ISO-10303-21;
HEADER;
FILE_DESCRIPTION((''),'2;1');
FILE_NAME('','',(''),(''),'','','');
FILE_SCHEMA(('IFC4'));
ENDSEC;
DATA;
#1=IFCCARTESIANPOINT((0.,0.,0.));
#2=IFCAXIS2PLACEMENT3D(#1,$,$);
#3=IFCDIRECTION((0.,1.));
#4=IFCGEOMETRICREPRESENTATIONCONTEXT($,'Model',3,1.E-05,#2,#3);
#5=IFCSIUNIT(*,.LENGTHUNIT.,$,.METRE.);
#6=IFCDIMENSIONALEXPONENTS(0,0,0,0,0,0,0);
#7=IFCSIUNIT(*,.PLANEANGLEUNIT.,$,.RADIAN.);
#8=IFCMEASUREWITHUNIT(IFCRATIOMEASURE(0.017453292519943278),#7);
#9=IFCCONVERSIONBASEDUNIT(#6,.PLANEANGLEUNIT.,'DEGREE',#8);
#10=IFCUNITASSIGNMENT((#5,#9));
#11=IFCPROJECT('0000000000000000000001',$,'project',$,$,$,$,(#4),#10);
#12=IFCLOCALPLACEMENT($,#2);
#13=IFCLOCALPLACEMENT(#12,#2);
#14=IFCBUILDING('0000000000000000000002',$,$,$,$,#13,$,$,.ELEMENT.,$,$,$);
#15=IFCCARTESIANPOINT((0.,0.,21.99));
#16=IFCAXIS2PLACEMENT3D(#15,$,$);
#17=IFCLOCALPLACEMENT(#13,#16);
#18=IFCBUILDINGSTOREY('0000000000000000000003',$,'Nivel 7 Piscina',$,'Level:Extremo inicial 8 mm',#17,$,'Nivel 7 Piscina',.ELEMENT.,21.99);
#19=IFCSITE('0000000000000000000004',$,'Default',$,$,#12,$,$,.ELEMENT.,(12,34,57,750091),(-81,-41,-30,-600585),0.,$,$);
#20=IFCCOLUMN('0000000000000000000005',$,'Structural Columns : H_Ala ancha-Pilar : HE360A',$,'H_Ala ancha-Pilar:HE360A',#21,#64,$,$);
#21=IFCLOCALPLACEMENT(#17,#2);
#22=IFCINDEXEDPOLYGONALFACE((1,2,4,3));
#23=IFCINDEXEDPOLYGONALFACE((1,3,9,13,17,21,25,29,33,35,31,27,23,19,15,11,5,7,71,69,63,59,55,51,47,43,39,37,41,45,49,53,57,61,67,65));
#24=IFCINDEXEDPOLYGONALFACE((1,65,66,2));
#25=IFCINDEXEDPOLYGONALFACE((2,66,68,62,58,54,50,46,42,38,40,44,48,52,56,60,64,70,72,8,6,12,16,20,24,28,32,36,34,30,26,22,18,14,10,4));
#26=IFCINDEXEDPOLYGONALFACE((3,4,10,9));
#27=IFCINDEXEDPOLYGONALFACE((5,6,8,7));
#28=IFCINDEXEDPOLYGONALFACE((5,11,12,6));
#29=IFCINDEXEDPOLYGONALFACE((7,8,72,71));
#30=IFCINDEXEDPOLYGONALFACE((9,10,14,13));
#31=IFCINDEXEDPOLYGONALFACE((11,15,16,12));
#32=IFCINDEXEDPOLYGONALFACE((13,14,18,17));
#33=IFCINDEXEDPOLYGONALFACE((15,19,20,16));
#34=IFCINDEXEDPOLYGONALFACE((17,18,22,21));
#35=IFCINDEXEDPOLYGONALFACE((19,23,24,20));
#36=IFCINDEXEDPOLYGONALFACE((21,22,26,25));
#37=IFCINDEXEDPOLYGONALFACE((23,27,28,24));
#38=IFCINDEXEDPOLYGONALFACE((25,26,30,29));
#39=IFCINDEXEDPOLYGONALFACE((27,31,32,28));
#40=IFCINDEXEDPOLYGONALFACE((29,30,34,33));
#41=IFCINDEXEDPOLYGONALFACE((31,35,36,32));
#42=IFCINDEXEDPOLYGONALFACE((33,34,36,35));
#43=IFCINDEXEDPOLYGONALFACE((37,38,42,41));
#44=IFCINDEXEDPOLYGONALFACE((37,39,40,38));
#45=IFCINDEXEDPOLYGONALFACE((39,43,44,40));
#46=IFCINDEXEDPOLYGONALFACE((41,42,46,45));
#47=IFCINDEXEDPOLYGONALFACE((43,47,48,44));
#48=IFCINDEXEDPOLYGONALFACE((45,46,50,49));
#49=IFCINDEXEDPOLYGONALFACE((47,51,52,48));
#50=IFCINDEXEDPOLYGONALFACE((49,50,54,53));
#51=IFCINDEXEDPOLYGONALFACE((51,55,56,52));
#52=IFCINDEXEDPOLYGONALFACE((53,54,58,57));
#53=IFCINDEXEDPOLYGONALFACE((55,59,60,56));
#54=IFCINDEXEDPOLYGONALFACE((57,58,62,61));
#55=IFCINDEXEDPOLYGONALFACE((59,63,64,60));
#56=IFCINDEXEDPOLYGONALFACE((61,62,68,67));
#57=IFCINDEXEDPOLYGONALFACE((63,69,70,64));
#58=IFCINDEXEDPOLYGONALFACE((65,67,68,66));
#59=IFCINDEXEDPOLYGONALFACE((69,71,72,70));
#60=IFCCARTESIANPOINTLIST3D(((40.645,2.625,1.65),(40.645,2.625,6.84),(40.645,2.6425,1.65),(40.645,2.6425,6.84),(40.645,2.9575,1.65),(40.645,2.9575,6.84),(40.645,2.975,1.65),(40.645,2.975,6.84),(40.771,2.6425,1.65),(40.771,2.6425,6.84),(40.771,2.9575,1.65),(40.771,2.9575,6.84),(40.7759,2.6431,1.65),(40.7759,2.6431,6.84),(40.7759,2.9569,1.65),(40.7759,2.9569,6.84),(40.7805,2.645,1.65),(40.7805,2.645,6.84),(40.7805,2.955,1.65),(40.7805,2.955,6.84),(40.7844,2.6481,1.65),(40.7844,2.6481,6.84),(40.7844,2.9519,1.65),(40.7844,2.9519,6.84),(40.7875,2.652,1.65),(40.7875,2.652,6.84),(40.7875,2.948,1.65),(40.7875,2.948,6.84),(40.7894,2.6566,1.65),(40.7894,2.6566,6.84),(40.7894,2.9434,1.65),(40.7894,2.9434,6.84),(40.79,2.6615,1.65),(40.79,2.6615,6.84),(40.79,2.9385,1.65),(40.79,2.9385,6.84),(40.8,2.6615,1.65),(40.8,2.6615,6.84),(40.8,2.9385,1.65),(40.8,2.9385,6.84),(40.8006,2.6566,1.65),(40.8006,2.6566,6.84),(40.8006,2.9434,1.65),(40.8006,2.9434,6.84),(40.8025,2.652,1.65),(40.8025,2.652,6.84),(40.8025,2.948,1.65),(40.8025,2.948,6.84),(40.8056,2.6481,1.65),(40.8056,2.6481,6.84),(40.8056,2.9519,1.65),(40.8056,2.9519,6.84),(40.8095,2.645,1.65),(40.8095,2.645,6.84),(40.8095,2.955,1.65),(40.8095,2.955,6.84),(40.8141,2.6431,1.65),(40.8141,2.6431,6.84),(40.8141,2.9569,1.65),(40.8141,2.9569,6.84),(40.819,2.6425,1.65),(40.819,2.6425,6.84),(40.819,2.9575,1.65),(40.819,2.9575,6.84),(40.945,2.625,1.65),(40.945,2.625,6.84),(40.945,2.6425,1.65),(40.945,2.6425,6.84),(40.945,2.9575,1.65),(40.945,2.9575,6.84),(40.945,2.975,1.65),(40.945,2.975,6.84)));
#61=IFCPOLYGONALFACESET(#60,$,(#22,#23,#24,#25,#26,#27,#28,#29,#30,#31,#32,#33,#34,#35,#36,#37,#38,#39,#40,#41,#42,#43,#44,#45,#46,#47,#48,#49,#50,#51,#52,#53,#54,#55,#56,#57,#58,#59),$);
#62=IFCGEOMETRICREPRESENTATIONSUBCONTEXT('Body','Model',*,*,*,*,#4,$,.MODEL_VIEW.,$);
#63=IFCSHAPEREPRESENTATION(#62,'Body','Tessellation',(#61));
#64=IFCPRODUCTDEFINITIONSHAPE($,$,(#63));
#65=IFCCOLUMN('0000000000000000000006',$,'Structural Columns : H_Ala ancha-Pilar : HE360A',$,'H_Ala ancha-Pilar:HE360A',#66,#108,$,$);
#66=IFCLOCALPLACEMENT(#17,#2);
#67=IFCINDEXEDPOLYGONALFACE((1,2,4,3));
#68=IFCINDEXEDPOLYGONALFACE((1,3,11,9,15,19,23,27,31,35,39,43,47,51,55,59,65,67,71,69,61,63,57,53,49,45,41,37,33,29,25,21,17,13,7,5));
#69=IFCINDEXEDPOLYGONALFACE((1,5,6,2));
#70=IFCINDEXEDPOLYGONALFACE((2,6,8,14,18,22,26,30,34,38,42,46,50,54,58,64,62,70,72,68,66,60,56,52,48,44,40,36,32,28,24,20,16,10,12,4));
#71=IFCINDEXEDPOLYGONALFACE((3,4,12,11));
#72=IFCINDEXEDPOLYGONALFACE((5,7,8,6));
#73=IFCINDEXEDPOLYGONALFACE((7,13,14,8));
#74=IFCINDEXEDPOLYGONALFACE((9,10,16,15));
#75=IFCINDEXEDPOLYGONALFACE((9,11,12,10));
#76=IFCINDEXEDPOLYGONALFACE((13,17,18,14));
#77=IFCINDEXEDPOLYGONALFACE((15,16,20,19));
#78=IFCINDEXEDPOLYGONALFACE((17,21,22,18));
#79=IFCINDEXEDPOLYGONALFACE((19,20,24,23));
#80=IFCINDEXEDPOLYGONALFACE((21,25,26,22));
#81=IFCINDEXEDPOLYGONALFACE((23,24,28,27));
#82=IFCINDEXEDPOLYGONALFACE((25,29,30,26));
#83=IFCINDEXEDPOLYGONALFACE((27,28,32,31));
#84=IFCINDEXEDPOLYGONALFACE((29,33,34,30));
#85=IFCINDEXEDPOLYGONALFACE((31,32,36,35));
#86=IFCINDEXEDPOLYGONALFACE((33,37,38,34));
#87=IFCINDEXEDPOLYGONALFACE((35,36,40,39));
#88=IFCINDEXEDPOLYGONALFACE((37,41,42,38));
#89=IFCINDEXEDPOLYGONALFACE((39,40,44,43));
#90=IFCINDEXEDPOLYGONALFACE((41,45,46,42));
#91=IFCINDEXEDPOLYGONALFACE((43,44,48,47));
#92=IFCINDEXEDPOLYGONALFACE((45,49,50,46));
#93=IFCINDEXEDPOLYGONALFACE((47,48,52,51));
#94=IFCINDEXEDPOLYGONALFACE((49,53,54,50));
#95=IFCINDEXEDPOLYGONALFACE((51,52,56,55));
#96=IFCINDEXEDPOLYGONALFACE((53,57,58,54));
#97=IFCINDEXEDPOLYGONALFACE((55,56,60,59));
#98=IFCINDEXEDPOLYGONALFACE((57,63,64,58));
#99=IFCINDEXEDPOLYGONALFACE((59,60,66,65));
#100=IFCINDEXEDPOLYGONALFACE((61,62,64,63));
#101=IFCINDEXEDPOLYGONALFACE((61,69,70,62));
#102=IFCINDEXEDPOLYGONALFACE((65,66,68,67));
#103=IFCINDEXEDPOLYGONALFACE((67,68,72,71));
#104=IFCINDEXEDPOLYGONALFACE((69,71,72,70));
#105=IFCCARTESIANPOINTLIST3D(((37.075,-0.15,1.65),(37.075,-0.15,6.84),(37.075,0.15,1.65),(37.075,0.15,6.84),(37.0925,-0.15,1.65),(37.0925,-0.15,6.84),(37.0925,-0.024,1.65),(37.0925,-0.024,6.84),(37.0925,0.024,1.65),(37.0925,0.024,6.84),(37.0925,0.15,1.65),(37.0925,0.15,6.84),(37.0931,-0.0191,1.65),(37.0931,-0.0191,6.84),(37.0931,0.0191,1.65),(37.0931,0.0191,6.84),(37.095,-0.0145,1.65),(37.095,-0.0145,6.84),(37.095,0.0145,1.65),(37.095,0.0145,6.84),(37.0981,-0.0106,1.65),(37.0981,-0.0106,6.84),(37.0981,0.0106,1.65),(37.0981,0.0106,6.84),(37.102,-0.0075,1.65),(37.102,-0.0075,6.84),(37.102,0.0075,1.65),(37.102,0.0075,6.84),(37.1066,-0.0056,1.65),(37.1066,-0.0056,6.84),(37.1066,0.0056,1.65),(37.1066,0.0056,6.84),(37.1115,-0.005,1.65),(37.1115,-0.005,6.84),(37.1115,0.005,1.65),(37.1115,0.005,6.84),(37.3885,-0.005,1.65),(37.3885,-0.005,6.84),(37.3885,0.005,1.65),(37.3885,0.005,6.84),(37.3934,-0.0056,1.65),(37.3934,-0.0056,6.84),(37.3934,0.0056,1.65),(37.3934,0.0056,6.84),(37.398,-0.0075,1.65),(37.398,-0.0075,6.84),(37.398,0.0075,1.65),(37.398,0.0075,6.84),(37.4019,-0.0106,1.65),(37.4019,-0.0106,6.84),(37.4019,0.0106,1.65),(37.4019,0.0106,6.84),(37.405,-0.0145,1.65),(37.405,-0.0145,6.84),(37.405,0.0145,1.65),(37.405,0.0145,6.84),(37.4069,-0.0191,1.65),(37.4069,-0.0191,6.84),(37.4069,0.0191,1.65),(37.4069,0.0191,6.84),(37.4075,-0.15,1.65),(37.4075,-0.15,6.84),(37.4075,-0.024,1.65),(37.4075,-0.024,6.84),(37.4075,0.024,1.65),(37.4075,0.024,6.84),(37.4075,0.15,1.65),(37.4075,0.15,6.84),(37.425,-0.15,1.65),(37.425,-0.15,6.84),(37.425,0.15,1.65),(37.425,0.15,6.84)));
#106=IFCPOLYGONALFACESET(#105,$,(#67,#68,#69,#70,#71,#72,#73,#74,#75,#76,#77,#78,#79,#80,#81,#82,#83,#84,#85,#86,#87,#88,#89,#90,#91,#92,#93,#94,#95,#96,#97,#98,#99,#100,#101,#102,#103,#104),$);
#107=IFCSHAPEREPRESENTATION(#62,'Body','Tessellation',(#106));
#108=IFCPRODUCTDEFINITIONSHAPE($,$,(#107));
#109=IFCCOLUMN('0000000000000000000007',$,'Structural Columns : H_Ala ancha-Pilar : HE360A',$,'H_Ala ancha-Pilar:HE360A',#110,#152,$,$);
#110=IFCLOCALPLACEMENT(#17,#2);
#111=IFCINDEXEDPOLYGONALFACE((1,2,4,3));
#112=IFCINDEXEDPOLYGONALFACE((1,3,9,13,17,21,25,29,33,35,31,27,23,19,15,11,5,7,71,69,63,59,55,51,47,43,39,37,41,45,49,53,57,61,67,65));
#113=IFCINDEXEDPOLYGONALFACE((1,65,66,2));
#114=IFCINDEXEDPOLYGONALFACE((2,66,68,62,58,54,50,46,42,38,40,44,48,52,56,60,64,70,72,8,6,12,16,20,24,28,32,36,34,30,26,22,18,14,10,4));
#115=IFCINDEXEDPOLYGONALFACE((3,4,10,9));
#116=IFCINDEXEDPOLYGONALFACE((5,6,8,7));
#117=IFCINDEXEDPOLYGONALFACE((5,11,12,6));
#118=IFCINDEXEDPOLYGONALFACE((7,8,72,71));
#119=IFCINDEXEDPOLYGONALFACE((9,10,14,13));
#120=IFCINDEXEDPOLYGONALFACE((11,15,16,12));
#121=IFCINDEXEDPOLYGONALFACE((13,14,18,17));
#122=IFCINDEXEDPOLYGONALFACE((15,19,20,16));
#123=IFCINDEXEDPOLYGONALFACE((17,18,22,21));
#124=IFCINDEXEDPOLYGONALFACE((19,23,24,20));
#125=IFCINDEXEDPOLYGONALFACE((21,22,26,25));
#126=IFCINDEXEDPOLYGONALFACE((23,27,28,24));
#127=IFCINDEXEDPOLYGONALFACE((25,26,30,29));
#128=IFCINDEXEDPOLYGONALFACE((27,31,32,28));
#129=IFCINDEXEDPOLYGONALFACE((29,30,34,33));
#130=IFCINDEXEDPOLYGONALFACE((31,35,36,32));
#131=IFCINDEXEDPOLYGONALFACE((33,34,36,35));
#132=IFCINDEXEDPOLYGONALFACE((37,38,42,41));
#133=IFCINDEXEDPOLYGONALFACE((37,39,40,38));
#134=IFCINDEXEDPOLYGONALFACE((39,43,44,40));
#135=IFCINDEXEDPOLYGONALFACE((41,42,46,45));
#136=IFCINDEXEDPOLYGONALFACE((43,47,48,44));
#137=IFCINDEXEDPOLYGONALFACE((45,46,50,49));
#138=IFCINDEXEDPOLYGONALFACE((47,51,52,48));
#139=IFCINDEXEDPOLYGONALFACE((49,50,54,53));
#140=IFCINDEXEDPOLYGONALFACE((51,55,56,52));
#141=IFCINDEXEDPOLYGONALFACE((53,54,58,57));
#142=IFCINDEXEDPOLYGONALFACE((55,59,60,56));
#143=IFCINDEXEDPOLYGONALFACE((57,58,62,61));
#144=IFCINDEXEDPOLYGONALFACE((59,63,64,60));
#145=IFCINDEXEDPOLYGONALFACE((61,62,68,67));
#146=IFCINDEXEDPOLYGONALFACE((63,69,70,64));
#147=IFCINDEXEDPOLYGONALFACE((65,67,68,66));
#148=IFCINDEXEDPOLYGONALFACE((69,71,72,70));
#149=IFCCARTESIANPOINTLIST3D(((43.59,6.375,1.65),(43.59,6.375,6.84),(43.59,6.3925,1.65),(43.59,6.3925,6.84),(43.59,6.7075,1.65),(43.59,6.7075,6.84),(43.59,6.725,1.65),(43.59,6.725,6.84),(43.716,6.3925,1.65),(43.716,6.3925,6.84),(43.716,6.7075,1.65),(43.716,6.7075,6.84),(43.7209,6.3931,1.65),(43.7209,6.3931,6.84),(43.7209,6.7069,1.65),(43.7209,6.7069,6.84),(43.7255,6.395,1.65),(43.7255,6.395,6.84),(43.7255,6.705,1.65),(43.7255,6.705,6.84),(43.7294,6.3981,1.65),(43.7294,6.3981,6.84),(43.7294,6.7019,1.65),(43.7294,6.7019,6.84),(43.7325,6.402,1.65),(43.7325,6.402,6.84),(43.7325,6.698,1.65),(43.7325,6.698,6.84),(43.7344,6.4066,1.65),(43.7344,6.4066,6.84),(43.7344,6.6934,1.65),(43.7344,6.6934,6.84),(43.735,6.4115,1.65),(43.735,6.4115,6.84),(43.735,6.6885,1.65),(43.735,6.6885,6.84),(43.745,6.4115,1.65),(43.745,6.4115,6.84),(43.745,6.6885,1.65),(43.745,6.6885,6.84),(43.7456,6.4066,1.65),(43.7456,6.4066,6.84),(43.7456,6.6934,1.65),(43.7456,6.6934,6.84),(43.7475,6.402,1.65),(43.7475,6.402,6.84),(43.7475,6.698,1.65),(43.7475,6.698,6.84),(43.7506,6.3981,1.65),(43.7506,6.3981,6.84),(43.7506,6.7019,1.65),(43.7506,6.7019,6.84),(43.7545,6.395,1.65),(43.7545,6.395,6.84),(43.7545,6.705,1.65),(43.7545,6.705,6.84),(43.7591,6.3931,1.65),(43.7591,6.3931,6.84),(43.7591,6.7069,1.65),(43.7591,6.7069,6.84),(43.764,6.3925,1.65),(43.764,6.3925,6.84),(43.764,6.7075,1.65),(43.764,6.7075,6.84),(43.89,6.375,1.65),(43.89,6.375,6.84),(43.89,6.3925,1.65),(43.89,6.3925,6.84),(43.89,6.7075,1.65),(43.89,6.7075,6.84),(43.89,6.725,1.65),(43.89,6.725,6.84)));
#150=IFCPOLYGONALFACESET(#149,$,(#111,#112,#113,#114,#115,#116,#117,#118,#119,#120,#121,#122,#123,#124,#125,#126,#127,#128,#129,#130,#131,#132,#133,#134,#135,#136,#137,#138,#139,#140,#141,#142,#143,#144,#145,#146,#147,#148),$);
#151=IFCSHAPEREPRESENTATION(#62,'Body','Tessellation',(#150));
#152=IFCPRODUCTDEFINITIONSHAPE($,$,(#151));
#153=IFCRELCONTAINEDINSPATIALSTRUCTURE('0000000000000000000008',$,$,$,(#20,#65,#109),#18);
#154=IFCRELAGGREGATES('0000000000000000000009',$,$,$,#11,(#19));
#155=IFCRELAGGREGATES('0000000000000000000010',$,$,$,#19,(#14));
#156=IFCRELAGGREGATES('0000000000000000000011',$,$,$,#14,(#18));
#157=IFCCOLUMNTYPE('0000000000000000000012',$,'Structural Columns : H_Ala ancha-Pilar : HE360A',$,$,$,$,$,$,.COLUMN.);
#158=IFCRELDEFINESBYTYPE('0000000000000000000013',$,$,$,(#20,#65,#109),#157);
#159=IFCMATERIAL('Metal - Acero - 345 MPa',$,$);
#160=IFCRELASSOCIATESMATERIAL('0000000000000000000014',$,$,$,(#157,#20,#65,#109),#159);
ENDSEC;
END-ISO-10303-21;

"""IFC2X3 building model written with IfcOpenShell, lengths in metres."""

from ifc_helpers import new_model, entity, si_unit, converted_unit, direction, frame, frame_2d, origin, place, context, subcontext, project, spatial, polyline, circle_curve, parameter, trimmed, segment, composite_curve, outline, extrude, source, transform, mapped, material, type_object, type_shapes, element, save


model = new_model("IFC2X3")

# Units and contexts
model_context = context("Model", 3, precision=1e-05, world=origin(), true_north=direction((0.0, 1.0)))
body_context = subcontext(model_context, "Body", "Model", "MODEL_VIEW")
ifc_project = project(units=[si_unit("LENGTHUNIT", "METRE"), converted_unit("PLANEANGLEUNIT", "DEGREE", entity("IfcRatioMeasure", 0.017453292519943278), si_unit("PLANEANGLEUNIT", "RADIAN"), dimensions=[0, 0, 0, 0, 0, 0, 0])], contexts=[model_context])

# Site, building, storey
site_placement = place(None, origin())
site = spatial("IfcSite", under=ifc_project, at=site_placement, Name="Default", CompositionType="ELEMENT", RefLatitude=(12, 34, 57, 750091), RefLongitude=(-81, -41, -30, -600585), RefElevation=0.0)
building_placement = place(site_placement, origin())
building = spatial("IfcBuilding", under=site, at=building_placement, CompositionType="ELEMENT")
storey_placement = place(building_placement, frame((0.0, 0.0, 21.99)))
storey = spatial("IfcBuildingStorey", under=building, at=storey_placement, Name="Nivel 7 Piscina", ObjectType="Level:Extremo inicial 8 mm", LongName="Nivel 7 Piscina", CompositionType="ELEMENT", Elevation=21.99)

# Columns
ifc_material = material(Name="Metal - Acero - 345 MPa")
column_type = type_object("IfcColumnType", Name="Structural Columns : H_Ala ancha-Pilar : HE360A", PredefinedType="COLUMN", material=ifc_material)
shared_shape = source(origin(), body_context, "Body", "SweptSolid", [
    extrude(outline(composite_curve([segment(polyline([(0.1575, -0.15), (0.175, -0.15)]), True, "CONTINUOUS"), segment(polyline([(0.175, -0.15), (0.175, 0.15)]), True, "CONTINUOUS"), segment(polyline([(0.175, 0.15), (0.1575, 0.15)]), True, "CONTINUOUS"), segment(polyline([(0.1575, 0.15), (0.1575, 0.024)]), True, "CONTINUOUS"), segment(trimmed(circle_curve(frame_2d((0.1385, 0.024), x_axis=(1.0, 0.0)), 0.019), [parameter(270.0)], [parameter(0.0)], True, "PARAMETER"), False, "CONTINUOUS"), segment(polyline([(0.1385, 0.005), (-0.1385, 0.005)]), True, "CONTINUOUS"), segment(trimmed(circle_curve(frame_2d((-0.1385, 0.024), x_axis=(0.0, -1.0)), 0.019), [parameter(270.0)], [parameter(0.0)], True, "PARAMETER"), False, "CONTINUOUS"), segment(polyline([(-0.1575, 0.024), (-0.1575, 0.15)]), True, "CONTINUOUS"), segment(polyline([(-0.1575, 0.15), (-0.175, 0.15)]), True, "CONTINUOUS"), segment(polyline([(-0.175, 0.15), (-0.175, -0.15)]), True, "CONTINUOUS"), segment(polyline([(-0.175, -0.15), (-0.1575, -0.15)]), True, "CONTINUOUS"), segment(polyline([(-0.1575, -0.15), (-0.1575, -0.024)]), True, "CONTINUOUS"), segment(trimmed(circle_curve(frame_2d((-0.1385, -0.024), x_axis=(-1.0, 0.0)), 0.019), [parameter(270.0)], [parameter(0.0)], True, "PARAMETER"), False, "CONTINUOUS"), segment(polyline([(-0.1385, -0.005), (0.1385, -0.005)]), True, "CONTINUOUS"), segment(trimmed(circle_curve(frame_2d((0.1385, -0.024), x_axis=(0.0, 1.0)), 0.019), [parameter(270.0)], [parameter(0.0)], True, "PARAMETER"), False, "CONTINUOUS"), segment(polyline([(0.1575, -0.024), (0.1575, -0.15)]), True, "CONTINUOUS")], self_intersect=False)), frame((0.0, 0.0, 23.64), z_axis=(0.0, 0.0, 1.0), x_axis=(0.0, -1.0, 0.0)), (0.0, 0.0, 1.0), 5.19),
])
type_shapes(column_type, [shared_shape])
for number, where, z_axis, x_axis, name in (
    (1, (40.795, 2.8, -21.99), (0.0, 0.0, 1.0), (-1.0, 0.0, 0.0), "Structural Columns : H_Ala ancha-Pilar : HE360A"),
    (2, (37.25, 0.0, -21.99), (0.0, 0.0, 1.0), (0.0, -1.0, 0.0), "Structural Columns : H_Ala ancha-Pilar : HE360A"),
    (3, (43.74, 6.55, -21.99), (0.0, 0.0, 1.0), (-1.0, 0.0, 0.0), "Structural Columns : H_Ala ancha-Pilar : HE360A"),
):
    element("IfcColumn", number, at=place(storey_placement, frame(where, z_axis=z_axis, x_axis=x_axis)), inside=storey, type_object=column_type, material=ifc_material, Name=name, ObjectType="H_Ala ancha-Pilar:HE360A", context=body_context, shape_type="MappedRepresentation", body=[
        mapped(shared_shape, transform((0.0, 0.0, 0.0), scale=1.0)),
    ])

save(model, "model.ifc")
